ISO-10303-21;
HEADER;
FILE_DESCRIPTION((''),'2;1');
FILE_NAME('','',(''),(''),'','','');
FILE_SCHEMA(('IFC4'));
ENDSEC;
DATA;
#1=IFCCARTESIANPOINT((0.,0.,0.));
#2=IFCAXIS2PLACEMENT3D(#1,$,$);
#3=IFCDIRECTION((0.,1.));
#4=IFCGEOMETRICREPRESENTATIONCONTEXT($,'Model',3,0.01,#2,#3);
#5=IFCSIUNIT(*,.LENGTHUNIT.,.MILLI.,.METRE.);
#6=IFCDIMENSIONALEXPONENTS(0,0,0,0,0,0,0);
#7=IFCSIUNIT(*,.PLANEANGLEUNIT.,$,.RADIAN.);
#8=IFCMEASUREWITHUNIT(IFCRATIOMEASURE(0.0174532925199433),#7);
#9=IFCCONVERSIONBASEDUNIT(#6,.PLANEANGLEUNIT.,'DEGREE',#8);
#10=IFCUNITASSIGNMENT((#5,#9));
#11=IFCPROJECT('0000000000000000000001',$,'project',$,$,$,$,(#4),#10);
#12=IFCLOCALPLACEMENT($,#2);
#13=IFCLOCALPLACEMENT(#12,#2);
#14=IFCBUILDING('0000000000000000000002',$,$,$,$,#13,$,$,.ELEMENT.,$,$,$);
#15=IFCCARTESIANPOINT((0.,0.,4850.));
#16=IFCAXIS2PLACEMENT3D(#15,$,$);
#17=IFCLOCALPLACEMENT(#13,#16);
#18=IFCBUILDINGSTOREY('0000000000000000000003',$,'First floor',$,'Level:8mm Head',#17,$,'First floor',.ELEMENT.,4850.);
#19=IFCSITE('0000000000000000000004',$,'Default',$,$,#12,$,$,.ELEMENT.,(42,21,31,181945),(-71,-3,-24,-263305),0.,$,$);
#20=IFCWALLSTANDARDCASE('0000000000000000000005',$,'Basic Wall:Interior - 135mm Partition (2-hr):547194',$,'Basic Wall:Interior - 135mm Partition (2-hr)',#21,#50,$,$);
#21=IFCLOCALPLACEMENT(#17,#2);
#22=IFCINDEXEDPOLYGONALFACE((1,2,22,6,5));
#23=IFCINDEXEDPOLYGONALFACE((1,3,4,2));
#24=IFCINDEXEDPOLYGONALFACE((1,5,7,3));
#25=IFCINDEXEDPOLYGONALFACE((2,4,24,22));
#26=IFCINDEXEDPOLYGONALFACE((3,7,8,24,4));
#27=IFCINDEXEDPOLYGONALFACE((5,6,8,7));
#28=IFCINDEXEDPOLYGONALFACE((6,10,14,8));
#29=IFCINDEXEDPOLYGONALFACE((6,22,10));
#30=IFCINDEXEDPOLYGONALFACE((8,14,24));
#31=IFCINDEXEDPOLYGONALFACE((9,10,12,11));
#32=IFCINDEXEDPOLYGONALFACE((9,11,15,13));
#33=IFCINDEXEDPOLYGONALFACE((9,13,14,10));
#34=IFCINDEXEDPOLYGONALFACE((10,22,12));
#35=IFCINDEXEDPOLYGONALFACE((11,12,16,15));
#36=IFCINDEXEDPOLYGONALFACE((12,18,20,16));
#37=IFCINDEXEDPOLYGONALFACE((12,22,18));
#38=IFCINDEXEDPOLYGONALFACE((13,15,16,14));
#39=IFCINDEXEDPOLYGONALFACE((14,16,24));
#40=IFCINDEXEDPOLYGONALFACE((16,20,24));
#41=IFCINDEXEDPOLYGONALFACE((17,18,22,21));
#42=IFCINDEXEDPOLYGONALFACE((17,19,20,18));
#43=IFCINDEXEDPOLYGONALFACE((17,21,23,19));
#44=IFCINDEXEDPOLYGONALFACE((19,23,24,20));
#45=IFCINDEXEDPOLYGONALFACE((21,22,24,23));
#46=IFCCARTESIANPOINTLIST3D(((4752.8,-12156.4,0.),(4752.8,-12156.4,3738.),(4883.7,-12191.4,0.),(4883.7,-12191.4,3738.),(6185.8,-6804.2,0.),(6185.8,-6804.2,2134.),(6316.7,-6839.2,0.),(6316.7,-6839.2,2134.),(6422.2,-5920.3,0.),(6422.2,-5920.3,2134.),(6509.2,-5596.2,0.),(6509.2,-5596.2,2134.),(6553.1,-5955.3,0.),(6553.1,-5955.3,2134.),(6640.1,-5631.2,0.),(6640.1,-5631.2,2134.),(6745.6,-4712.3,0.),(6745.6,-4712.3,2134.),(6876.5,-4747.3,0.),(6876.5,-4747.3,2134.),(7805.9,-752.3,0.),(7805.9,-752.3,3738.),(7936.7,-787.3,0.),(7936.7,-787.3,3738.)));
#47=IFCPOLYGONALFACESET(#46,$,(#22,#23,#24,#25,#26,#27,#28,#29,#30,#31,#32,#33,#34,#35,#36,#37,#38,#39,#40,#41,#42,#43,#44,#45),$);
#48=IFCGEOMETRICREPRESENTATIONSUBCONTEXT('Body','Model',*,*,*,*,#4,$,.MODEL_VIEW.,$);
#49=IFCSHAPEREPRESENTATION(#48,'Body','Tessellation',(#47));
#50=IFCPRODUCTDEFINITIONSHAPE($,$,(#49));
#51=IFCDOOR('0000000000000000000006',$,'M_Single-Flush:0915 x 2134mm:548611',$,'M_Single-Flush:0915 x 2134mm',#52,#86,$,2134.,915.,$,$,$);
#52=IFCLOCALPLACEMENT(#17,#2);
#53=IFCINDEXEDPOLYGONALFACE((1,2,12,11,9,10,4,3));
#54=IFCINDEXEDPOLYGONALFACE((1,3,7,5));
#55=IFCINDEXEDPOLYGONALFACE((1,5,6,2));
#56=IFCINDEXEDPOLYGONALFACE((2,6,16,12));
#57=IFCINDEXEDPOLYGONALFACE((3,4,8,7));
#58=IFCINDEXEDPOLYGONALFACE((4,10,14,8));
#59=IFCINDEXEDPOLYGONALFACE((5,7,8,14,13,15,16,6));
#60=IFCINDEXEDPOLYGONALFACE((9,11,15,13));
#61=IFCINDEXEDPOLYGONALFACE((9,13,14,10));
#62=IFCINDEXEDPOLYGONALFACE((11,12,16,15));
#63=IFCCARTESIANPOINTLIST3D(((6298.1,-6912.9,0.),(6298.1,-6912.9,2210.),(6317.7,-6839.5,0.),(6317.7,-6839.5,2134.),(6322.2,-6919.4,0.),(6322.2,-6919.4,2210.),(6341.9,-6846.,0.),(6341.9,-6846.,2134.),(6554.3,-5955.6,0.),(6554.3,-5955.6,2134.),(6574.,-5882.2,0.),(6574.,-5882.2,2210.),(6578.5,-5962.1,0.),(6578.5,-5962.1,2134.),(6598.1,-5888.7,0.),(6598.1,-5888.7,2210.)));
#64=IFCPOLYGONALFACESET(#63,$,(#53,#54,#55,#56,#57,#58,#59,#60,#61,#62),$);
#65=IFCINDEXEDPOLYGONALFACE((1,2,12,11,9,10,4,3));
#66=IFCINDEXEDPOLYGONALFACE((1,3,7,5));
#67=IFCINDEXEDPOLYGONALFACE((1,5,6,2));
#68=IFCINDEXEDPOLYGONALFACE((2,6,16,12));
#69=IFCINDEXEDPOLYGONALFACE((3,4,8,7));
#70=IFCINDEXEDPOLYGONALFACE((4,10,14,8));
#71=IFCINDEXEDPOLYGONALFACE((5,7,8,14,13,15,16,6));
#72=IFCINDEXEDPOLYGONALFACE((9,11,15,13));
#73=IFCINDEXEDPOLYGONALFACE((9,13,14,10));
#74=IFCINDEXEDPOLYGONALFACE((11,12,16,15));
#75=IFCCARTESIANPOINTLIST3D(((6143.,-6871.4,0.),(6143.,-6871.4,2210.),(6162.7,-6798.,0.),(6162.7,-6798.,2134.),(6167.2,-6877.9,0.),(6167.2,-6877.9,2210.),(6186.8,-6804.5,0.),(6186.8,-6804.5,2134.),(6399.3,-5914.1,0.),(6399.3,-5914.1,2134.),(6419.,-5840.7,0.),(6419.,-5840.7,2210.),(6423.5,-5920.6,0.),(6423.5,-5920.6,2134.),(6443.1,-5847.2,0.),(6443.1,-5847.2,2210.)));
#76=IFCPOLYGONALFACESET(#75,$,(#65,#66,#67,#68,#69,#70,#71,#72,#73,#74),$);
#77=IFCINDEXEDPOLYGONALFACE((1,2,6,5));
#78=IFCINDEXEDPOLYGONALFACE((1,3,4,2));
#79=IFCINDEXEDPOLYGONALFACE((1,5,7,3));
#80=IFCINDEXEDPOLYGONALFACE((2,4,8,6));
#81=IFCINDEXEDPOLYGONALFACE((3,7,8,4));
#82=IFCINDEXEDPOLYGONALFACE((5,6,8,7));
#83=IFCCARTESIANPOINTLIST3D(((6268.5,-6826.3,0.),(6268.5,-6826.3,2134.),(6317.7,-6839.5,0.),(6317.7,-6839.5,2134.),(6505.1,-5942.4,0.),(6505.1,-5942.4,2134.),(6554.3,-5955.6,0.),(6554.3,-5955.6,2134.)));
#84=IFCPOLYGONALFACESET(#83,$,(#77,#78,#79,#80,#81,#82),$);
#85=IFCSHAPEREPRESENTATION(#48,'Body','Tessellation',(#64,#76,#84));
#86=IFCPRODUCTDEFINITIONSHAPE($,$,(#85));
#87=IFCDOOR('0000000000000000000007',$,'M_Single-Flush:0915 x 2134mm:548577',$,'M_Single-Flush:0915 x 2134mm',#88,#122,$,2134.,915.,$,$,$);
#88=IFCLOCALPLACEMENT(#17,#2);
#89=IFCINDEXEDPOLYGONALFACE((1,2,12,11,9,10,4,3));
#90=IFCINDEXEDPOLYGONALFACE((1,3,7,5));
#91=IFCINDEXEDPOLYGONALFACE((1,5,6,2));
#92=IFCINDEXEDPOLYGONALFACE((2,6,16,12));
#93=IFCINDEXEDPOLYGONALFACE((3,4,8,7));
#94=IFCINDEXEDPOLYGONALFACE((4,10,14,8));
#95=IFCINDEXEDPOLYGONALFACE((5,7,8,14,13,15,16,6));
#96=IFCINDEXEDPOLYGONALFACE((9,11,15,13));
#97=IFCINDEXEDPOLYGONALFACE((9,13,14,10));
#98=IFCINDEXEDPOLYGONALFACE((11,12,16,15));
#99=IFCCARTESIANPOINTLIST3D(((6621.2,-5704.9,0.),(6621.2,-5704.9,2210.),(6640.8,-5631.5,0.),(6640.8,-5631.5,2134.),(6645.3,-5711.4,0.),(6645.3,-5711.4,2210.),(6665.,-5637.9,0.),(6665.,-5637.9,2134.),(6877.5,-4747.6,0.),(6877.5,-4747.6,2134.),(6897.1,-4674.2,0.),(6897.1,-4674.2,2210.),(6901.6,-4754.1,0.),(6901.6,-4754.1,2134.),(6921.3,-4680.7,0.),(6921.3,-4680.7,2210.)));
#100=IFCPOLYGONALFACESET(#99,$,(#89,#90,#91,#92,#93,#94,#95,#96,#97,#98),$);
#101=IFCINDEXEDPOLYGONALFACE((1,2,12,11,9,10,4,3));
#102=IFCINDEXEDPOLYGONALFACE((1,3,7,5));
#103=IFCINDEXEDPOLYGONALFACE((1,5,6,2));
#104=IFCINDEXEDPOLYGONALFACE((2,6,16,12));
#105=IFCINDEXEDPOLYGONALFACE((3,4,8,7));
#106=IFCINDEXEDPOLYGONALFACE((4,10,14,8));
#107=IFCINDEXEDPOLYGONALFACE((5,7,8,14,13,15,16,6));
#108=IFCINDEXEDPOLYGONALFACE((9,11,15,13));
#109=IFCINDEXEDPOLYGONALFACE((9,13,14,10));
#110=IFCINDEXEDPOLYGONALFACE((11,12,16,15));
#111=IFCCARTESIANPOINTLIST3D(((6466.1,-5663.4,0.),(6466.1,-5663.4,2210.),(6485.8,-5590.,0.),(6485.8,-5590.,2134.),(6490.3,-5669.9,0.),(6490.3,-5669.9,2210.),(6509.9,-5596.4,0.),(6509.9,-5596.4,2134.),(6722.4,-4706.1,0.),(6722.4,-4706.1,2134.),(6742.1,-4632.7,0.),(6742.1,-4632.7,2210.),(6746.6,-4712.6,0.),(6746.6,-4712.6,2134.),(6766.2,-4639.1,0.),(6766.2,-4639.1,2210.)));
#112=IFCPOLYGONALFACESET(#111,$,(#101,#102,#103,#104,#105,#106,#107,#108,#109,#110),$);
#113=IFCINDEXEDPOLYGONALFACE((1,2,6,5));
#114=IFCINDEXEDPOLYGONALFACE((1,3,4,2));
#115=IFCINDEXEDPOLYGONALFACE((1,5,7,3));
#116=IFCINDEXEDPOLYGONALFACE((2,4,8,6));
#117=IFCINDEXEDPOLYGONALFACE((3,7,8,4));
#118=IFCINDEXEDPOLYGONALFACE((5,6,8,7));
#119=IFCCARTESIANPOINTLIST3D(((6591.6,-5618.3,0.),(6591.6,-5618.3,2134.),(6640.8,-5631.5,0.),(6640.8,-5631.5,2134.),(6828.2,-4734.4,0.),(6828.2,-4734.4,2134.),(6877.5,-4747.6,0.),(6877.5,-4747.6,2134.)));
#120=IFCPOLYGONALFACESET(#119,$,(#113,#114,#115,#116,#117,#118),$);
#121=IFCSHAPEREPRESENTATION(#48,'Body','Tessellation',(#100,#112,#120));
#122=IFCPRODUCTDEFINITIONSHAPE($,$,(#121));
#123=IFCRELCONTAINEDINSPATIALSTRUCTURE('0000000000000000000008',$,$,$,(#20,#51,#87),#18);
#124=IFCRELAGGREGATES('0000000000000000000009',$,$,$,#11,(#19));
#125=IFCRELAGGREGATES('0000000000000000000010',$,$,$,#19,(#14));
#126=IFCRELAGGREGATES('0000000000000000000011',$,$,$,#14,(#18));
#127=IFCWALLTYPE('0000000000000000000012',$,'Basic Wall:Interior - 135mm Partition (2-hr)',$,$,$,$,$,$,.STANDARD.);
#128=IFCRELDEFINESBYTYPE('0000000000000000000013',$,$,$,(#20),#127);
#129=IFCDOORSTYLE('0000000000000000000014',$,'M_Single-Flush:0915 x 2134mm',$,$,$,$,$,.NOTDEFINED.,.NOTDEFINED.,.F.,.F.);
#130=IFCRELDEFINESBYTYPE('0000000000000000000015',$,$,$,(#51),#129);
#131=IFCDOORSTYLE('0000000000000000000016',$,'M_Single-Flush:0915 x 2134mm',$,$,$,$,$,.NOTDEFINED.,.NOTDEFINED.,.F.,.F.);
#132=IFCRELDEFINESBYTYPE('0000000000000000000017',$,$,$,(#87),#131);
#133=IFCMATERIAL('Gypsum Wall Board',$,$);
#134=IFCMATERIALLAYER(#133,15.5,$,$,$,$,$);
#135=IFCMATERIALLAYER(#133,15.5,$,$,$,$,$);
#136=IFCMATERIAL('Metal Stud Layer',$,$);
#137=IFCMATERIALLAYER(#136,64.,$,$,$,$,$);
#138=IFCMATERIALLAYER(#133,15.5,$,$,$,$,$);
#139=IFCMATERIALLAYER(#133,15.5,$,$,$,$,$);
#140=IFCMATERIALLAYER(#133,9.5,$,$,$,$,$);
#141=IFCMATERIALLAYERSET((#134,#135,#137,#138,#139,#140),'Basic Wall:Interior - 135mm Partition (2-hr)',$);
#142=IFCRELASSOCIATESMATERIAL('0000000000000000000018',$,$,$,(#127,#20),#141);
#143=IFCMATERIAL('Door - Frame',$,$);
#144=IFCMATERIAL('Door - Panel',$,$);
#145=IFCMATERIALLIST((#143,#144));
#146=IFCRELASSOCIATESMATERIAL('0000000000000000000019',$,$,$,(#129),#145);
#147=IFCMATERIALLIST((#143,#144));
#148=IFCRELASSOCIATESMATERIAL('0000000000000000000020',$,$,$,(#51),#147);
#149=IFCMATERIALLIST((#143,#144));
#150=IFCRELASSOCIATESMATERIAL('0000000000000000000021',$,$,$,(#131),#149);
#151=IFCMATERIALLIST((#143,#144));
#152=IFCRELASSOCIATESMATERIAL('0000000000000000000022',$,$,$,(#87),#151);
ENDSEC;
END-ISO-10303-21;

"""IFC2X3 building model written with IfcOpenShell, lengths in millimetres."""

from ifc_helpers import new_model, entity, si_unit, converted_unit, direction, frame, frame_2d, origin, place, context, subcontext, project, spatial, polyline, rectangle, outline, extrude, source, transform, mapped, material, material_list, layer, layer_set, layer_usage, type_object, type_shapes, element, fill, save


model = new_model("IFC2X3")

# Units and contexts
model_context = context("Model", 3, precision=0.01, world=origin(), true_north=direction((0.0, 1.0)))
body_context = subcontext(model_context, "Body", "Model", "MODEL_VIEW")
ifc_project = project(units=[si_unit("LENGTHUNIT", "METRE", prefix="MILLI"), converted_unit("PLANEANGLEUNIT", "DEGREE", entity("IfcRatioMeasure", 0.0174532925199433), si_unit("PLANEANGLEUNIT", "RADIAN"), dimensions=[0, 0, 0, 0, 0, 0, 0])], contexts=[model_context])

# Site, building, storey
site_placement = place(None, origin())
site = spatial("IfcSite", under=ifc_project, at=site_placement, Name="Default", CompositionType="ELEMENT", RefLatitude=(42, 21, 31, 181945), RefLongitude=(-71, -3, -24, -263305), RefElevation=0.0)
building_placement = place(site_placement, origin())
building = spatial("IfcBuilding", under=site, at=building_placement, CompositionType="ELEMENT")
storey_placement = place(building_placement, frame((0.0, 0.0, 4850.0)))
storey = spatial("IfcBuildingStorey", under=building, at=storey_placement, Name="First floor", ObjectType="Level:8mm Head", LongName="First floor", CompositionType="ELEMENT", Elevation=4850.0)

# Shared definitions
ifc_material_1 = material(Name="Gypsum Wall Board")

# Wall, openings, doors
ifc_layer_1 = layer(ifc_material_1, 15.5)
ifc_layer_2 = layer(ifc_material_1, 15.5)
ifc_material_2 = material(Name="Metal Stud Layer")
ifc_layer_3 = layer(ifc_material_2, 64.0)
ifc_layer_4 = layer(ifc_material_1, 15.5)
ifc_layer_5 = layer(ifc_material_1, 15.5)
ifc_layer_6 = layer(ifc_material_1, 9.5)
ifc_layer_set_1 = layer_set([ifc_layer_1, ifc_layer_2, ifc_layer_3, ifc_layer_4, ifc_layer_5, ifc_layer_6], Name="Basic Wall:Interior - 135mm Partition (2-hr)")
ifc_layer_usage_1 = layer_usage(ifc_layer_set_1, "AXIS2", "NEGATIVE", 67.8)
wall_type_1 = type_object("IfcWallType", Name="Basic Wall:Interior - 135mm Partition (2-hr)", PredefinedType="STANDARD", material=ifc_layer_set_1)
wall_1_placement = place(storey_placement, frame((7871.3, -769.8, 0.0), z_axis=(0.0, 0.0, 1.0), x_axis=(-0.258607, -0.965983, 0.0)))
wall_1 = element("IfcWallStandardCase", 1, at=wall_1_placement, inside=storey, type_object=wall_type_1, material=ifc_layer_usage_1, Name="Basic Wall:Interior - 135mm Partition (2-hr):547194", ObjectType="Basic Wall:Interior - 135mm Partition (2-hr)", context=body_context, shape_type="SweptSolid", body=[
    extrude(rectangle(XDim=11805.7, YDim=135.5, at=frame_2d((5902.8, 0.0), x_axis=(-1.0, 0.0))), origin(), (0.0, 0.0, 1.0), 3738.0),
])
opening_1_placement = place(wall_1_placement, frame((4099.5, -67.9, 0.0)))
opening_1 = element("IfcOpeningElement", 2, at=opening_1_placement, cuts=wall_1, ObjectType="Opening", context=body_context, shape_type="SweptSolid", body=[
    extrude(rectangle(XDim=915.0, YDim=2134.0, at=frame_2d((1067.0, 457.5), x_axis=(0.0, 1.0))), frame((0.0, 0.0, 0.0), z_axis=(-0.00022, 1.0, 0.0), x_axis=(0.0, 0.0, 1.0)), (0.0, 0.0, 1.0), 135.5),
])
opening_2_placement = place(wall_1_placement, frame((5350.0, -67.9, 0.0)))
opening_2 = element("IfcOpeningElement", 3, at=opening_2_placement, cuts=wall_1, ObjectType="Opening", context=body_context, shape_type="SweptSolid", body=[
    extrude(rectangle(XDim=915.0, YDim=2134.0, at=frame_2d((1067.0, 457.5), x_axis=(0.0, -1.0))), frame((0.0, 0.0, 0.0), z_axis=(-0.00022, 1.0, 0.0), x_axis=(0.0, 0.0, 1.0)), (0.0, 0.0, 1.0), 135.5),
])
ifc_material_3 = material(Name="Door - Frame")
ifc_material_4 = material(Name="Door - Panel")
ifc_material_list_1 = material_list([ifc_material_3, ifc_material_4])
ifc_material_list_2 = material_list([ifc_material_3, ifc_material_4])
door_style_1 = type_object("IfcDoorStyle", Name="M_Single-Flush:0915 x 2134mm", ConstructionType="NOTDEFINED", OperationType="NOTDEFINED", ParameterTakesPrecedence=False, Sizeable=False, material=ifc_material_list_2)
shared_shape_1 = source(origin(), body_context, "Body", "SweptSolid", [
    extrude(outline(polyline([(-533.5, -1124.0), (533.5, -1124.0), (533.5, 1086.0), (457.5, 1086.0), (457.5, -1048.0), (-457.5, -1048.0), (-457.5, 1086.0), (-533.5, 1086.0), (-533.5, -1124.0)])), frame((457.5, 160.5, 1086.0), z_axis=(0.0, -1.0, 0.0), x_axis=(-1.0, 0.0, 0.0)), (0.0, 0.0, 1.0), 25.0),
    extrude(outline(polyline([(-1124.0, -533.5), (1086.0, -533.5), (1086.0, -457.5), (-1048.0, -457.5), (-1048.0, 457.5), (1086.0, 457.5), (1086.0, 533.5), (-1124.0, 533.5), (-1124.0, -533.5)])), frame((457.5, 0.0, 1086.0), z_axis=(0.0, -1.0, 0.0), x_axis=(0.0, 0.0, -1.0)), (0.0, 0.0, 1.0), 25.0),
    extrude(rectangle(XDim=915.0, YDim=51.0, at=frame_2d((0.0, 0.0), x_axis=(1.0, 0.0))), frame((457.5, 110.0, 0.0)), (0.0, 0.0, 1.0), 2134.0),
])
type_shapes(door_style_1, [shared_shape_1])
door_1_placement = place(opening_2_placement, frame((0.0, 1.3, 0.0)))
door_1 = element("IfcDoor", 4, at=door_1_placement, inside=storey, type_object=door_style_1, material=ifc_material_list_1, Name="M_Single-Flush:0915 x 2134mm:548611", ObjectType="M_Single-Flush:0915 x 2134mm", OverallHeight=2134.0, OverallWidth=915.0, context=body_context, shape_type="MappedRepresentation", body=[
    mapped(shared_shape_1, transform((0.0, 0.0, 0.0), scale=1.0)),
])
fill(opening_2, door_1)
ifc_material_list_3 = material_list([ifc_material_3, ifc_material_4])
ifc_material_list_4 = material_list([ifc_material_3, ifc_material_4])
door_style_2 = type_object("IfcDoorStyle", Name="M_Single-Flush:0915 x 2134mm", ConstructionType="NOTDEFINED", OperationType="NOTDEFINED", ParameterTakesPrecedence=False, Sizeable=False, material=ifc_material_list_4)
shared_shape_2 = source(origin(), body_context, "Body", "SweptSolid", [
    extrude(outline(polyline([(-533.5, -1124.0), (533.5, -1124.0), (533.5, 1086.0), (457.5, 1086.0), (457.5, -1048.0), (-457.5, -1048.0), (-457.5, 1086.0), (-533.5, 1086.0), (-533.5, -1124.0)])), frame((457.5, 135.5, 1086.0), z_axis=(0.0, 1.0, 0.0), x_axis=(1.0, 0.0, 0.0)), (0.0, 0.0, 1.0), 25.0),
    extrude(outline(polyline([(-1124.0, -533.5), (1086.0, -533.5), (1086.0, -457.5), (-1048.0, -457.5), (-1048.0, 457.5), (1086.0, 457.5), (1086.0, 533.5), (-1124.0, 533.5), (-1124.0, -533.5)])), frame((457.5, -25.0, 1086.0), z_axis=(0.0, 1.0, 0.0), x_axis=(0.0, 0.0, -1.0)), (0.0, 0.0, 1.0), 25.0),
    extrude(rectangle(XDim=51.0, YDim=915.0, at=frame_2d((0.0, 0.0), x_axis=(1.0, 0.0))), frame((457.5, 110.0, 0.0), z_axis=(0.0, 0.0, 1.0), x_axis=(0.0, 1.0, 0.0)), (0.0, 0.0, 1.0), 2134.0),
])
type_shapes(door_style_2, [shared_shape_2])
door_2_placement = place(opening_1_placement, frame((0.0, 1.0, 0.0)))
door_2 = element("IfcDoor", 5, at=door_2_placement, inside=storey, type_object=door_style_2, material=ifc_material_list_3, Name="M_Single-Flush:0915 x 2134mm:548577", ObjectType="M_Single-Flush:0915 x 2134mm", OverallHeight=2134.0, OverallWidth=915.0, context=body_context, shape_type="MappedRepresentation", body=[
    mapped(shared_shape_2, transform((0.0, 0.0, 0.0), scale=1.0)),
])
fill(opening_1, door_2)

save(model, "model.ifc")
